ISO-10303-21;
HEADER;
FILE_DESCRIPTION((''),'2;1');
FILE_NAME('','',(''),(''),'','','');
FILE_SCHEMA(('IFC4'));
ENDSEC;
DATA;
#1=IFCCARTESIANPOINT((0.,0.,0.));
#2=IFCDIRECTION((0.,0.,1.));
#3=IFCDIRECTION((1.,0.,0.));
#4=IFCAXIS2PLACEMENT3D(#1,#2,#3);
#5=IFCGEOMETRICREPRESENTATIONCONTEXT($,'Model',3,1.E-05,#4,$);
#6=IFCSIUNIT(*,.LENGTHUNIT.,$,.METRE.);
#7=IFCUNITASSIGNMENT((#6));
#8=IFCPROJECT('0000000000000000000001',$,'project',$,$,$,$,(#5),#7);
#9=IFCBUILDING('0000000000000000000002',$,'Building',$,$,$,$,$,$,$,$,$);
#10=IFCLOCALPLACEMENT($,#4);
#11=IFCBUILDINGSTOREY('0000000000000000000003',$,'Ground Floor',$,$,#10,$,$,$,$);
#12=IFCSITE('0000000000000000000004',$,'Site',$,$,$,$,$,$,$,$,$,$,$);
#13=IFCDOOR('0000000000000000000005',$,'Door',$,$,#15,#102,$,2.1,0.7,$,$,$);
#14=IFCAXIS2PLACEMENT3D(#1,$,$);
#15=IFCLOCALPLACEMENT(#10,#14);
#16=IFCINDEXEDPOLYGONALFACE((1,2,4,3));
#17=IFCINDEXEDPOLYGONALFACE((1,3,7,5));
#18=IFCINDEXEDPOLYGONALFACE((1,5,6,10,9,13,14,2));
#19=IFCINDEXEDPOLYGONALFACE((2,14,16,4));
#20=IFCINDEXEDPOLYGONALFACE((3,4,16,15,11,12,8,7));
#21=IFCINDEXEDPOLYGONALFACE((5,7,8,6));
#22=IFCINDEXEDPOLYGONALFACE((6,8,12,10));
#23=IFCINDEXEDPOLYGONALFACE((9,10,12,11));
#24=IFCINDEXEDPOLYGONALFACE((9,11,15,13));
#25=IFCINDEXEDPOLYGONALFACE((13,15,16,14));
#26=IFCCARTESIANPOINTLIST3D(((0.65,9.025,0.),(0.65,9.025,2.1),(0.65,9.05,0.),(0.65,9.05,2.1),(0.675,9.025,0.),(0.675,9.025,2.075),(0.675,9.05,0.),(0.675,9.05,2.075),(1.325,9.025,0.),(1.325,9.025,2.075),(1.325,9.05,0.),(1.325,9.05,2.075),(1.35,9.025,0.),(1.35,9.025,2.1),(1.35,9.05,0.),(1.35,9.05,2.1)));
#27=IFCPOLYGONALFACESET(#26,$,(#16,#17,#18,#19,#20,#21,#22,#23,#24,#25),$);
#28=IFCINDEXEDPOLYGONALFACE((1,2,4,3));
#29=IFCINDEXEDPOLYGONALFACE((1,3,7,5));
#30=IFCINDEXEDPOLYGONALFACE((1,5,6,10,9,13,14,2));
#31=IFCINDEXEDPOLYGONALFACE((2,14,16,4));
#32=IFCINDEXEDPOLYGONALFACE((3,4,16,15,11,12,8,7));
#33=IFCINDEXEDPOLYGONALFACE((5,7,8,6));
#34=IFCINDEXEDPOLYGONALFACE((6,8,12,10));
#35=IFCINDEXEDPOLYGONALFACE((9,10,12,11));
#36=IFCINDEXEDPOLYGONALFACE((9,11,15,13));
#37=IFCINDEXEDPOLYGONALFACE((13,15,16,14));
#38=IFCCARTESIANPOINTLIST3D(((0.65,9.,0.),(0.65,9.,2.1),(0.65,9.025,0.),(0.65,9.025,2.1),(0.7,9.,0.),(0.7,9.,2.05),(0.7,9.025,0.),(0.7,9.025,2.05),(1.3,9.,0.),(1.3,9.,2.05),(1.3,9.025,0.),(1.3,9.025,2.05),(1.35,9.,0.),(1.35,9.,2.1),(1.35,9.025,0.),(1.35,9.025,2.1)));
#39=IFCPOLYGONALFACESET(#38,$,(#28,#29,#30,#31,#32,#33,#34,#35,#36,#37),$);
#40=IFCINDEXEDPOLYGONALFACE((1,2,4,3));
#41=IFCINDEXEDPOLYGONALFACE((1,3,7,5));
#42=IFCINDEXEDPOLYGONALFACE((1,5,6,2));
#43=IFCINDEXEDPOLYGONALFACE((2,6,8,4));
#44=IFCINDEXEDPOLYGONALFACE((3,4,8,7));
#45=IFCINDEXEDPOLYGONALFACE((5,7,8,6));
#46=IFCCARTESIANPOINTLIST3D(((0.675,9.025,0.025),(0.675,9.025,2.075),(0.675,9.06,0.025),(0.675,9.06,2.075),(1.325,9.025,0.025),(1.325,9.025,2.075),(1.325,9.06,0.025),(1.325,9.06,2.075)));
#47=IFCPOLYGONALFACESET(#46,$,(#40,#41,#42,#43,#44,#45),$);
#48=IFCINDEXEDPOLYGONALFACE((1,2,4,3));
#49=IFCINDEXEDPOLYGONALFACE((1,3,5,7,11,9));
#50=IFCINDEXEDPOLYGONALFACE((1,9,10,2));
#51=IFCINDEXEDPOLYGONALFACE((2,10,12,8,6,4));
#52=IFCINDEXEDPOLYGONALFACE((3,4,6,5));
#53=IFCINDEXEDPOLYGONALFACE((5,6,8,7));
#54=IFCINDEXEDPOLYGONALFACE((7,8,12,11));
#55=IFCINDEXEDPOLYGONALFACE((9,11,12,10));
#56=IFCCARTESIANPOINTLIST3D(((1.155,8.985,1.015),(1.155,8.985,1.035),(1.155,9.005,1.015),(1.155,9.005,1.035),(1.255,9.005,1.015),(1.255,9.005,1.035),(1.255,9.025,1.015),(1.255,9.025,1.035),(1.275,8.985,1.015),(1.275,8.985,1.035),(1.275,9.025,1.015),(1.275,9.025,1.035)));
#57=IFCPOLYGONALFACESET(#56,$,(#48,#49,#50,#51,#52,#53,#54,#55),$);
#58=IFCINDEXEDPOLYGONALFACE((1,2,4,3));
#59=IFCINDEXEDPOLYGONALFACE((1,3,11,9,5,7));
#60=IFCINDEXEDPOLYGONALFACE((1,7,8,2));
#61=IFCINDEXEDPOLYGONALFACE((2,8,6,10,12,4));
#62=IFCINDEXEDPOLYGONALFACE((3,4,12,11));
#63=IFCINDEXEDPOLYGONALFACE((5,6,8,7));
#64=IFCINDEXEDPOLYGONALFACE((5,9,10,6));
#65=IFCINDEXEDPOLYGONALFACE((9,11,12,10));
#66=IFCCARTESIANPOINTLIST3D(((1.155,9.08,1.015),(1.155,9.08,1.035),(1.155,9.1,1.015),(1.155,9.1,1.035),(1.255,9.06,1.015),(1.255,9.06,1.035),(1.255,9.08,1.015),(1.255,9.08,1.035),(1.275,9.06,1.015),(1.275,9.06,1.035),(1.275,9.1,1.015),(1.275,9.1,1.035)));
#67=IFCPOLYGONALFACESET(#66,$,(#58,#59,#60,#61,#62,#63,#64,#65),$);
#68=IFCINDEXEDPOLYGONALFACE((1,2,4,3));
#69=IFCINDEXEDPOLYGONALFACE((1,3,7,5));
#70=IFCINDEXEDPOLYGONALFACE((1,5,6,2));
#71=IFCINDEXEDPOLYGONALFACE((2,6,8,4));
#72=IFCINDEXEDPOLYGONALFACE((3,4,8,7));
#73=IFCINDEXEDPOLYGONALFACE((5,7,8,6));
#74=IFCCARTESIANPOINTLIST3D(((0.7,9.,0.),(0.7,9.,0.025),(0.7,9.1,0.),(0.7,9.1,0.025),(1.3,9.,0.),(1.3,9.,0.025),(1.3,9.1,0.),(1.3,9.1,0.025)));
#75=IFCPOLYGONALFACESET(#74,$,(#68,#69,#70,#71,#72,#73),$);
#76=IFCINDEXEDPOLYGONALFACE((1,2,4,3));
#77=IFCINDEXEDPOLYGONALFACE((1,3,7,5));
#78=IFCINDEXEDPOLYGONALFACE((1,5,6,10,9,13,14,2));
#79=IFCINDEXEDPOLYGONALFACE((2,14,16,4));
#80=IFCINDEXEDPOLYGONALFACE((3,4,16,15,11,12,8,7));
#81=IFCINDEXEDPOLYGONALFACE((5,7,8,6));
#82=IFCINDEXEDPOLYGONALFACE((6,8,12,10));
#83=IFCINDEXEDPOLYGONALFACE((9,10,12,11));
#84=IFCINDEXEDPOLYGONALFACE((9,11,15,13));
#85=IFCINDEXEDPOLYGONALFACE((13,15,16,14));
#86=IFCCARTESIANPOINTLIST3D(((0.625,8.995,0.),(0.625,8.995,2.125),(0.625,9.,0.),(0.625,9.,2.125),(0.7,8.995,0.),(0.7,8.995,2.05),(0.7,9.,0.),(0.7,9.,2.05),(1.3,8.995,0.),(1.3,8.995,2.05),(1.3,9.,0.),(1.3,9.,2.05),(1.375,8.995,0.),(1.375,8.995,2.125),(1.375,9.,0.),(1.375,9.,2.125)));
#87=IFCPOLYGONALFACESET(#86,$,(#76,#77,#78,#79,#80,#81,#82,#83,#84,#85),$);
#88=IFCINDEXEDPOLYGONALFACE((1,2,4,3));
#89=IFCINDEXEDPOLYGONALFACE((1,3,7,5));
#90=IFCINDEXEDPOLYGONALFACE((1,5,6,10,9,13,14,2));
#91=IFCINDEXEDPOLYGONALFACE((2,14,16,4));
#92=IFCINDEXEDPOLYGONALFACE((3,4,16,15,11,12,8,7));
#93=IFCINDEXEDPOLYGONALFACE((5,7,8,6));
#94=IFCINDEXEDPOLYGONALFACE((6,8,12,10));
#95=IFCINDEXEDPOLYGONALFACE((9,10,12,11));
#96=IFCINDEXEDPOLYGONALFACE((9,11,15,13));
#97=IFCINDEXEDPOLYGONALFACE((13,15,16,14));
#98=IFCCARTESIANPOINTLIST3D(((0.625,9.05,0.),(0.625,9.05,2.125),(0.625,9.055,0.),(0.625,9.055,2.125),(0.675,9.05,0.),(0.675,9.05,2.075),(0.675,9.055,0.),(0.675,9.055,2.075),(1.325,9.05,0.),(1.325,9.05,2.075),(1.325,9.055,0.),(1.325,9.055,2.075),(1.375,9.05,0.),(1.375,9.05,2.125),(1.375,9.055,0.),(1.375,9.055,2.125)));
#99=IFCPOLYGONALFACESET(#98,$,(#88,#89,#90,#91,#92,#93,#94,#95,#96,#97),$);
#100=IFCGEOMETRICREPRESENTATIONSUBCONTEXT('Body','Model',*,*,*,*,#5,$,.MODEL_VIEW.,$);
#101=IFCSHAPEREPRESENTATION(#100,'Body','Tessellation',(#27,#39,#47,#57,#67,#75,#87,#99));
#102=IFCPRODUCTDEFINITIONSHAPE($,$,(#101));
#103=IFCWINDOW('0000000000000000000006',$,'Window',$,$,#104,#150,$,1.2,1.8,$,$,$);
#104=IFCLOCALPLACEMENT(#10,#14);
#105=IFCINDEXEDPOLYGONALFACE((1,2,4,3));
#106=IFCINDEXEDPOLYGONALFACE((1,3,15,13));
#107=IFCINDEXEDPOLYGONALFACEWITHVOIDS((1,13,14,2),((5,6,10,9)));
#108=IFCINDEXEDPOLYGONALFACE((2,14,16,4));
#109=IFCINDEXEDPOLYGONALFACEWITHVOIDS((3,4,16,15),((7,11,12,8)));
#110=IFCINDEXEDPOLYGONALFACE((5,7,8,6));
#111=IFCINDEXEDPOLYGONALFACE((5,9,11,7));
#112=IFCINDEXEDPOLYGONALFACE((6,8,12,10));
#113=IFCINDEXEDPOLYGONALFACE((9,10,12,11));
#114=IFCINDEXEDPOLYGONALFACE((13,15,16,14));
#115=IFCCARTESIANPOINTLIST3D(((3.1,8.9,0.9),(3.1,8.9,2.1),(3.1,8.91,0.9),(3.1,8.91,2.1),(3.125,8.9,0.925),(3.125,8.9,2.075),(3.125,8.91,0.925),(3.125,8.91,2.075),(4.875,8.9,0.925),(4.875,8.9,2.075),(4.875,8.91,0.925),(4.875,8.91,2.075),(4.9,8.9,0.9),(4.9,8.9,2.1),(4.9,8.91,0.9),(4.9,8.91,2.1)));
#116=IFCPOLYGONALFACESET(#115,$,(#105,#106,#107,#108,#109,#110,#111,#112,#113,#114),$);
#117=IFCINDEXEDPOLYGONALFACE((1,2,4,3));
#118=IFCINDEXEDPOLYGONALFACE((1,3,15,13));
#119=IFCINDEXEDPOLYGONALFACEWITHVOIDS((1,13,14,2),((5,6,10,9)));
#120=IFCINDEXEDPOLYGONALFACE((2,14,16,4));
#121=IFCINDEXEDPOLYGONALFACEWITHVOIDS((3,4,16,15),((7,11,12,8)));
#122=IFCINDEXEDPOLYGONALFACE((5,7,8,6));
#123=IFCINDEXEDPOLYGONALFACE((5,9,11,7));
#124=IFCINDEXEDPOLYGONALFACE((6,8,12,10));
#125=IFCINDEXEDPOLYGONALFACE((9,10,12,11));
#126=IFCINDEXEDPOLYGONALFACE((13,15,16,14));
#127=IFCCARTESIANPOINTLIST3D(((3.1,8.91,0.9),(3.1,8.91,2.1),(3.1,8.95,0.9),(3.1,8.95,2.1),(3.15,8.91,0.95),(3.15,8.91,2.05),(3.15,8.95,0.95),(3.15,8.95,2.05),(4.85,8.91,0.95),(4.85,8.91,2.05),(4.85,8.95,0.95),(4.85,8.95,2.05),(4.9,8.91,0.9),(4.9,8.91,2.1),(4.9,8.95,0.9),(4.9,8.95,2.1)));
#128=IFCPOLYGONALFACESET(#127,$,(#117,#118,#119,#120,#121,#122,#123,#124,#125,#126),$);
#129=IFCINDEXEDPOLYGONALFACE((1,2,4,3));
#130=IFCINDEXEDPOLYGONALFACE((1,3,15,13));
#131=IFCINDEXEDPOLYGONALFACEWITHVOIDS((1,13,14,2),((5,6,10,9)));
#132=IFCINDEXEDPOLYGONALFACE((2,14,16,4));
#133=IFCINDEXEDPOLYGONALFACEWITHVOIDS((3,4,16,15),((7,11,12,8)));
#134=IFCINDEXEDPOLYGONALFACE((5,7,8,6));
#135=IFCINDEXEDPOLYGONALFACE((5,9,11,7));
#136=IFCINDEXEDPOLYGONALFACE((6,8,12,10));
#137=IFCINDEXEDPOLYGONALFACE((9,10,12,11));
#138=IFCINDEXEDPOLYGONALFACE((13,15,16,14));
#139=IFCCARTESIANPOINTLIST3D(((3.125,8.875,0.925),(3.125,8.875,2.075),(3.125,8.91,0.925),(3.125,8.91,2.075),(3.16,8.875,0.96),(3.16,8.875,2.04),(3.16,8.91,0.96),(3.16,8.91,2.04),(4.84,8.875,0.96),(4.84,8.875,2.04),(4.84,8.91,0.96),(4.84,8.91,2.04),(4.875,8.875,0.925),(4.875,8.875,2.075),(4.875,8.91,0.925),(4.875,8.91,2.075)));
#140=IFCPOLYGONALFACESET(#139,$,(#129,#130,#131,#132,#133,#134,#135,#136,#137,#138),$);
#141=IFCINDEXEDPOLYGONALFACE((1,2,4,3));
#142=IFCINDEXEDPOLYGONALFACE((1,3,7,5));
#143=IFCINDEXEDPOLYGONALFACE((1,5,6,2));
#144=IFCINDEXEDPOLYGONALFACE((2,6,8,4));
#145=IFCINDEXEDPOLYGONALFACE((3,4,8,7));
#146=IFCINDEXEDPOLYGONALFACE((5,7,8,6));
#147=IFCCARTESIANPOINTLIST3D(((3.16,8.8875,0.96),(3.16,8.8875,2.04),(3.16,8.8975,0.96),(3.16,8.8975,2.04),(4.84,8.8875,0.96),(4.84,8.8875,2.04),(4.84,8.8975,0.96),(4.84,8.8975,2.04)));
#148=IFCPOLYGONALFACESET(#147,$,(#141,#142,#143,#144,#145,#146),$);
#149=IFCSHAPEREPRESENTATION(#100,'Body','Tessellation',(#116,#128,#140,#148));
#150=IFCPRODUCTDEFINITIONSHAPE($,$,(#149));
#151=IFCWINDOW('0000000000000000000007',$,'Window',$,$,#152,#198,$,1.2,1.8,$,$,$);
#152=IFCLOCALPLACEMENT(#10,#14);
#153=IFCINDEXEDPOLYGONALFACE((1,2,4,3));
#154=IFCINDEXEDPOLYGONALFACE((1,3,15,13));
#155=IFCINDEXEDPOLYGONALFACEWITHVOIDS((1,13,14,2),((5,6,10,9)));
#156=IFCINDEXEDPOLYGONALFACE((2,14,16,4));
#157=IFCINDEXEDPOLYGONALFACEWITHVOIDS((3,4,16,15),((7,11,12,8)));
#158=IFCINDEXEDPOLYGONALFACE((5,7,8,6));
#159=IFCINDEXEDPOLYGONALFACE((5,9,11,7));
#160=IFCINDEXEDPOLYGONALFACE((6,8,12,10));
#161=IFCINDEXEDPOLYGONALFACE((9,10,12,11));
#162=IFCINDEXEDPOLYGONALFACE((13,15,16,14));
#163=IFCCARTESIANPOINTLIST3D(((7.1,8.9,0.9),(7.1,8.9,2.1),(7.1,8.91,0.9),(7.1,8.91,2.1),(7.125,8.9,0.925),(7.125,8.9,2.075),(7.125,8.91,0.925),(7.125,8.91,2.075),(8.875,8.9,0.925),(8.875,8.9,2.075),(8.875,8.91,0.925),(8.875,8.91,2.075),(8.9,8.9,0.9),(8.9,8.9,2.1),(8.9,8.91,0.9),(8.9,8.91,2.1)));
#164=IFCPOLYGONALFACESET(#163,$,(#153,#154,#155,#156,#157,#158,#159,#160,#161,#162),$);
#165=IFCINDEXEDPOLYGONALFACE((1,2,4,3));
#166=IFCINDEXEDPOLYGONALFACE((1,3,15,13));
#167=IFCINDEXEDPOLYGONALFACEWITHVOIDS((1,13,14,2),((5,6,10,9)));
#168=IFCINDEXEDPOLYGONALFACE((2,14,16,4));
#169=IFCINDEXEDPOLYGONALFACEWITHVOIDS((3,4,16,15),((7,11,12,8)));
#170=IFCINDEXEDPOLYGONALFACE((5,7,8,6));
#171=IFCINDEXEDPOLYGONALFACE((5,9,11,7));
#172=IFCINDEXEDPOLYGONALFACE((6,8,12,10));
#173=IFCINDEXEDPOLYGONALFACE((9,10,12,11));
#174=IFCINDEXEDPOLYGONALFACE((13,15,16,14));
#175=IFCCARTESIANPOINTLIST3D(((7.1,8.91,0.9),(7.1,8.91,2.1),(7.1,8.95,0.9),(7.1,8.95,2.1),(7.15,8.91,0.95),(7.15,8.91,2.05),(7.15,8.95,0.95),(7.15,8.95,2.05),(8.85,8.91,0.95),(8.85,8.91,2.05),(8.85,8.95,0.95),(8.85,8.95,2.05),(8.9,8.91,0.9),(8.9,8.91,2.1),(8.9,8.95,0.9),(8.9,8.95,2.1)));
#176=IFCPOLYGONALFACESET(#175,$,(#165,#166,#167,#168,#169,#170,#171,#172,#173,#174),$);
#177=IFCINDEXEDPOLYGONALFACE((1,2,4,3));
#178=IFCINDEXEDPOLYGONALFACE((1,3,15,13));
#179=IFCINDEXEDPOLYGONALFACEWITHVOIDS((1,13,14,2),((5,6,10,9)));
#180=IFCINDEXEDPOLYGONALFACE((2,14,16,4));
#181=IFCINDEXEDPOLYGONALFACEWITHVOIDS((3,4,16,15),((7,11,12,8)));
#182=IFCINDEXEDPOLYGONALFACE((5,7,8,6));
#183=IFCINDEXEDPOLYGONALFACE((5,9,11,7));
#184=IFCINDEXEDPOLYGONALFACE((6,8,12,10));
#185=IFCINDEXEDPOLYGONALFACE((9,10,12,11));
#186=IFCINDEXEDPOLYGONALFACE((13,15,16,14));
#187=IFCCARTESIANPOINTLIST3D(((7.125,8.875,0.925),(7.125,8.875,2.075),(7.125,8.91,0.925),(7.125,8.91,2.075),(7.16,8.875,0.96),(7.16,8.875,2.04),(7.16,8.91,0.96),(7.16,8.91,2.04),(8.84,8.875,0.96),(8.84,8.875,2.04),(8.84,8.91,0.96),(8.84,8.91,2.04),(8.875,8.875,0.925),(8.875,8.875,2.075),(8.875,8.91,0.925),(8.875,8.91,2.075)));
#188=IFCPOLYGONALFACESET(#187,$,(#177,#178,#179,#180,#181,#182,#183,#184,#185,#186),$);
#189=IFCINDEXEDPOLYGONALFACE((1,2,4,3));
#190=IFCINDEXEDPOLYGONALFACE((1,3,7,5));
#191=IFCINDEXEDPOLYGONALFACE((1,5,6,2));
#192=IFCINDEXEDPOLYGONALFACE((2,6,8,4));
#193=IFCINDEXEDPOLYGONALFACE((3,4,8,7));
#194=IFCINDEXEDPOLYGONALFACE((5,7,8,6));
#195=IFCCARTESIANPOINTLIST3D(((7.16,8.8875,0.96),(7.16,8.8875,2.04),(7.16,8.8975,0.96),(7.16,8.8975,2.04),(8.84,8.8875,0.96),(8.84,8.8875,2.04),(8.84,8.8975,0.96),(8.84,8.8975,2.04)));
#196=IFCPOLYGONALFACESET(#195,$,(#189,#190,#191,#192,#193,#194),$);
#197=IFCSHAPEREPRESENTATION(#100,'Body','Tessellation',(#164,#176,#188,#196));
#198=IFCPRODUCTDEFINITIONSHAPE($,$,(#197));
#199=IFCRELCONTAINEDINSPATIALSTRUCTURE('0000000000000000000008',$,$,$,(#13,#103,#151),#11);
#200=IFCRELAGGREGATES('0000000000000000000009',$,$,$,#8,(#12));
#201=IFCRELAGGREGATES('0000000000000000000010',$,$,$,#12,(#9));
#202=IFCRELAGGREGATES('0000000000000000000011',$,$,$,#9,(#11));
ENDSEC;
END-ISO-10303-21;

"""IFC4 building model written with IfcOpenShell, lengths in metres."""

from ifc_helpers import new_model, si_unit, frame, origin_with_axes, place, context, subcontext, project, spatial, line, indexed_curve, outline, extrude, element, save


model = new_model("IFC4")

# Units and contexts
model_context = context("Model", 3, precision=1e-05, world=origin_with_axes())
body_context = subcontext(model_context, "Body", "Model", "MODEL_VIEW")
ifc_project = project(units=[si_unit("LENGTHUNIT", "METRE")], contexts=[model_context])

# Site, building, storey
site = spatial("IfcSite", under=ifc_project, Name="Site")
building = spatial("IfcBuilding", under=site, Name="Building")
storey_placement = place(None, origin_with_axes())
storey = spatial("IfcBuildingStorey", under=building, at=storey_placement, Name="Ground Floor")

# Door
door_1_placement = place(storey_placement, frame((0.65, 9.0, 0.0), z_axis=(0.0, 0.0, 1.0), x_axis=(1.0, 0.0, 0.0)))
element("IfcDoor", 1, at=door_1_placement, inside=storey, Name="Door", OverallHeight=2.1, OverallWidth=0.7, context=body_context, shape_type="SweptSolid", body=[
    extrude(outline(indexed_curve([(0.0, 0.0), (0.0, 2.1), (0.7, 2.1), (0.7, 0.0), (0.675, 0.0), (0.675, 2.075), (0.025, 2.075), (0.025, 0.0)], segments=[line(1, 2, 3, 4, 5, 6, 7, 8, 1)])), frame((0.0, 0.025, 0.0), z_axis=(0.0, -1.0, 0.0), x_axis=(1.0, 0.0, 0.0)), (0.0, 0.0, -1.0), 0.025),
    extrude(outline(indexed_curve([(0.0, 0.0), (0.0, 2.1), (0.7, 2.1), (0.7, 0.0), (0.65, 0.0), (0.65, 2.05), (0.05, 2.05), (0.05, 0.0)], segments=[line(1, 2, 3, 4, 5, 6, 7, 8, 1)])), frame((0.0, 0.0, 0.0), z_axis=(0.0, -1.0, 0.0), x_axis=(1.0, 0.0, 0.0)), (0.0, 0.0, -1.0), 0.025),
    extrude(outline(indexed_curve([(0.0, 0.0), (0.65, 0.0), (0.65, 0.035), (0.0, 0.035)], segments=[line(1, 2, 3, 4, 1)])), frame((0.025, 0.025, 0.025), z_axis=(0.0, 0.0, 1.0), x_axis=(1.0, 0.0, 0.0)), (0.0, 0.0, 1.0), 2.05),
    extrude(outline(indexed_curve([(0.0, 0.0), (0.0, -0.04), (-0.12, -0.04), (-0.12, -0.02), (-0.02, -0.02), (-0.02, 0.0)], segments=[line(1, 2, 3, 4, 5, 6, 1)])), frame((0.625, 0.025, 1.015), z_axis=(0.0, 0.0, 1.0), x_axis=(1.0, 0.0, 0.0)), (0.0, 0.0, 1.0), 0.02),
    extrude(outline(indexed_curve([(0.0, 0.0), (0.0, 0.04), (-0.12, 0.04), (-0.12, 0.02), (-0.02, 0.02), (-0.02, 0.0)], segments=[line(1, 2, 3, 4, 5, 6, 1)])), frame((0.625, 0.06, 1.015), z_axis=(0.0, 0.0, 1.0), x_axis=(1.0, 0.0, 0.0)), (0.0, 0.0, 1.0), 0.02),
    extrude(outline(indexed_curve([(0.0, 0.0), (0.6, 0.0), (0.6, 0.1), (0.0, 0.1)], segments=[line(1, 2, 3, 4, 1)])), frame((0.05, 0.0, 0.0), z_axis=(0.0, 0.0, 1.0), x_axis=(1.0, 0.0, 0.0)), (0.0, 0.0, 1.0), 0.025),
    extrude(outline(indexed_curve([(0.0, 0.0), (0.0, 2.125), (0.75, 2.125), (0.75, 0.0), (0.675, 0.0), (0.675, 2.05), (0.075, 2.05), (0.075, 0.0)], segments=[line(1, 2, 3, 4, 5, 6, 7, 8, 1)])), frame((-0.025, -0.005, 0.0), z_axis=(0.0, -1.0, 0.0), x_axis=(1.0, 0.0, 0.0)), (0.0, 0.0, -1.0), 0.005),
    extrude(outline(indexed_curve([(0.0, 0.0), (0.0, 2.125), (0.75, 2.125), (0.75, 0.0), (0.7, 0.0), (0.7, 2.075), (0.05, 2.075), (0.05, 0.0)], segments=[line(1, 2, 3, 4, 5, 6, 7, 8, 1)])), frame((-0.025, 0.05, 0.0), z_axis=(0.0, -1.0, 0.0), x_axis=(1.0, 0.0, 0.0)), (0.0, 0.0, -1.0), 0.005),
])

# Windows
for number, where, z_axis, x_axis, name in (
    (2, (4.9, 9.0, 0.9), (0.0, 0.0, 1.0), (-1.0, 0.0, 0.0), "Window"),
    (3, (8.9, 9.0, 0.9), (0.0, 0.0, 1.0), (-1.0, 0.0, 0.0), "Window"),
):
    element("IfcWindow", number, at=place(storey_placement, frame(where, z_axis=z_axis, x_axis=x_axis)), inside=storey, Name=name, OverallHeight=1.2, OverallWidth=1.8, context=body_context, shape_type="SweptSolid", body=[
        extrude(outline(indexed_curve([(0.0, 0.0), (1.8, 0.0), (1.8, 1.2), (0.0, 1.2)], segments=[line(1, 2, 3, 4, 1)]), holes=[indexed_curve([(0.025, 0.025), (1.775, 0.025), (1.775, 1.175), (0.025, 1.175)], segments=[line(1, 2, 3, 4, 1)])]), frame((0.0, 0.09, 0.0), z_axis=(0.0, -1.0, 0.0), x_axis=(1.0, 0.0, 0.0)), (0.0, 0.0, -1.0), 0.01),
        extrude(outline(indexed_curve([(0.0, 0.0), (1.8, 0.0), (1.8, 1.2), (0.0, 1.2)], segments=[line(1, 2, 3, 4, 1)]), holes=[indexed_curve([(0.05, 0.05), (1.75, 0.05), (1.75, 1.15), (0.05, 1.15)], segments=[line(1, 2, 3, 4, 1)])]), frame((0.0, 0.05, 0.0), z_axis=(0.0, -1.0, 0.0), x_axis=(1.0, 0.0, 0.0)), (0.0, 0.0, -1.0), 0.04),
        extrude(outline(indexed_curve([(0.0, 0.0), (1.75, 0.0), (1.75, 1.15), (0.0, 1.15)], segments=[line(1, 2, 3, 4, 1)]), holes=[indexed_curve([(0.035, 0.035), (1.715, 0.035), (1.715, 1.115), (0.035, 1.115)], segments=[line(1, 2, 3, 4, 1)])]), frame((0.025, 0.09, 0.025), z_axis=(0.0, -1.0, 0.0), x_axis=(1.0, 0.0, 0.0)), (0.0, 0.0, -1.0), 0.035),
        extrude(outline(indexed_curve([(0.035, 0.035), (1.715, 0.035), (1.715, 1.115), (0.035, 1.115)], segments=[line(1, 2, 3, 4, 1)])), frame((0.025, 0.1025, 0.025), z_axis=(0.0, -1.0, 0.0), x_axis=(1.0, 0.0, 0.0)), (0.0, 0.0, -1.0), 0.01),
    ])

save(model, "model.ifc")
